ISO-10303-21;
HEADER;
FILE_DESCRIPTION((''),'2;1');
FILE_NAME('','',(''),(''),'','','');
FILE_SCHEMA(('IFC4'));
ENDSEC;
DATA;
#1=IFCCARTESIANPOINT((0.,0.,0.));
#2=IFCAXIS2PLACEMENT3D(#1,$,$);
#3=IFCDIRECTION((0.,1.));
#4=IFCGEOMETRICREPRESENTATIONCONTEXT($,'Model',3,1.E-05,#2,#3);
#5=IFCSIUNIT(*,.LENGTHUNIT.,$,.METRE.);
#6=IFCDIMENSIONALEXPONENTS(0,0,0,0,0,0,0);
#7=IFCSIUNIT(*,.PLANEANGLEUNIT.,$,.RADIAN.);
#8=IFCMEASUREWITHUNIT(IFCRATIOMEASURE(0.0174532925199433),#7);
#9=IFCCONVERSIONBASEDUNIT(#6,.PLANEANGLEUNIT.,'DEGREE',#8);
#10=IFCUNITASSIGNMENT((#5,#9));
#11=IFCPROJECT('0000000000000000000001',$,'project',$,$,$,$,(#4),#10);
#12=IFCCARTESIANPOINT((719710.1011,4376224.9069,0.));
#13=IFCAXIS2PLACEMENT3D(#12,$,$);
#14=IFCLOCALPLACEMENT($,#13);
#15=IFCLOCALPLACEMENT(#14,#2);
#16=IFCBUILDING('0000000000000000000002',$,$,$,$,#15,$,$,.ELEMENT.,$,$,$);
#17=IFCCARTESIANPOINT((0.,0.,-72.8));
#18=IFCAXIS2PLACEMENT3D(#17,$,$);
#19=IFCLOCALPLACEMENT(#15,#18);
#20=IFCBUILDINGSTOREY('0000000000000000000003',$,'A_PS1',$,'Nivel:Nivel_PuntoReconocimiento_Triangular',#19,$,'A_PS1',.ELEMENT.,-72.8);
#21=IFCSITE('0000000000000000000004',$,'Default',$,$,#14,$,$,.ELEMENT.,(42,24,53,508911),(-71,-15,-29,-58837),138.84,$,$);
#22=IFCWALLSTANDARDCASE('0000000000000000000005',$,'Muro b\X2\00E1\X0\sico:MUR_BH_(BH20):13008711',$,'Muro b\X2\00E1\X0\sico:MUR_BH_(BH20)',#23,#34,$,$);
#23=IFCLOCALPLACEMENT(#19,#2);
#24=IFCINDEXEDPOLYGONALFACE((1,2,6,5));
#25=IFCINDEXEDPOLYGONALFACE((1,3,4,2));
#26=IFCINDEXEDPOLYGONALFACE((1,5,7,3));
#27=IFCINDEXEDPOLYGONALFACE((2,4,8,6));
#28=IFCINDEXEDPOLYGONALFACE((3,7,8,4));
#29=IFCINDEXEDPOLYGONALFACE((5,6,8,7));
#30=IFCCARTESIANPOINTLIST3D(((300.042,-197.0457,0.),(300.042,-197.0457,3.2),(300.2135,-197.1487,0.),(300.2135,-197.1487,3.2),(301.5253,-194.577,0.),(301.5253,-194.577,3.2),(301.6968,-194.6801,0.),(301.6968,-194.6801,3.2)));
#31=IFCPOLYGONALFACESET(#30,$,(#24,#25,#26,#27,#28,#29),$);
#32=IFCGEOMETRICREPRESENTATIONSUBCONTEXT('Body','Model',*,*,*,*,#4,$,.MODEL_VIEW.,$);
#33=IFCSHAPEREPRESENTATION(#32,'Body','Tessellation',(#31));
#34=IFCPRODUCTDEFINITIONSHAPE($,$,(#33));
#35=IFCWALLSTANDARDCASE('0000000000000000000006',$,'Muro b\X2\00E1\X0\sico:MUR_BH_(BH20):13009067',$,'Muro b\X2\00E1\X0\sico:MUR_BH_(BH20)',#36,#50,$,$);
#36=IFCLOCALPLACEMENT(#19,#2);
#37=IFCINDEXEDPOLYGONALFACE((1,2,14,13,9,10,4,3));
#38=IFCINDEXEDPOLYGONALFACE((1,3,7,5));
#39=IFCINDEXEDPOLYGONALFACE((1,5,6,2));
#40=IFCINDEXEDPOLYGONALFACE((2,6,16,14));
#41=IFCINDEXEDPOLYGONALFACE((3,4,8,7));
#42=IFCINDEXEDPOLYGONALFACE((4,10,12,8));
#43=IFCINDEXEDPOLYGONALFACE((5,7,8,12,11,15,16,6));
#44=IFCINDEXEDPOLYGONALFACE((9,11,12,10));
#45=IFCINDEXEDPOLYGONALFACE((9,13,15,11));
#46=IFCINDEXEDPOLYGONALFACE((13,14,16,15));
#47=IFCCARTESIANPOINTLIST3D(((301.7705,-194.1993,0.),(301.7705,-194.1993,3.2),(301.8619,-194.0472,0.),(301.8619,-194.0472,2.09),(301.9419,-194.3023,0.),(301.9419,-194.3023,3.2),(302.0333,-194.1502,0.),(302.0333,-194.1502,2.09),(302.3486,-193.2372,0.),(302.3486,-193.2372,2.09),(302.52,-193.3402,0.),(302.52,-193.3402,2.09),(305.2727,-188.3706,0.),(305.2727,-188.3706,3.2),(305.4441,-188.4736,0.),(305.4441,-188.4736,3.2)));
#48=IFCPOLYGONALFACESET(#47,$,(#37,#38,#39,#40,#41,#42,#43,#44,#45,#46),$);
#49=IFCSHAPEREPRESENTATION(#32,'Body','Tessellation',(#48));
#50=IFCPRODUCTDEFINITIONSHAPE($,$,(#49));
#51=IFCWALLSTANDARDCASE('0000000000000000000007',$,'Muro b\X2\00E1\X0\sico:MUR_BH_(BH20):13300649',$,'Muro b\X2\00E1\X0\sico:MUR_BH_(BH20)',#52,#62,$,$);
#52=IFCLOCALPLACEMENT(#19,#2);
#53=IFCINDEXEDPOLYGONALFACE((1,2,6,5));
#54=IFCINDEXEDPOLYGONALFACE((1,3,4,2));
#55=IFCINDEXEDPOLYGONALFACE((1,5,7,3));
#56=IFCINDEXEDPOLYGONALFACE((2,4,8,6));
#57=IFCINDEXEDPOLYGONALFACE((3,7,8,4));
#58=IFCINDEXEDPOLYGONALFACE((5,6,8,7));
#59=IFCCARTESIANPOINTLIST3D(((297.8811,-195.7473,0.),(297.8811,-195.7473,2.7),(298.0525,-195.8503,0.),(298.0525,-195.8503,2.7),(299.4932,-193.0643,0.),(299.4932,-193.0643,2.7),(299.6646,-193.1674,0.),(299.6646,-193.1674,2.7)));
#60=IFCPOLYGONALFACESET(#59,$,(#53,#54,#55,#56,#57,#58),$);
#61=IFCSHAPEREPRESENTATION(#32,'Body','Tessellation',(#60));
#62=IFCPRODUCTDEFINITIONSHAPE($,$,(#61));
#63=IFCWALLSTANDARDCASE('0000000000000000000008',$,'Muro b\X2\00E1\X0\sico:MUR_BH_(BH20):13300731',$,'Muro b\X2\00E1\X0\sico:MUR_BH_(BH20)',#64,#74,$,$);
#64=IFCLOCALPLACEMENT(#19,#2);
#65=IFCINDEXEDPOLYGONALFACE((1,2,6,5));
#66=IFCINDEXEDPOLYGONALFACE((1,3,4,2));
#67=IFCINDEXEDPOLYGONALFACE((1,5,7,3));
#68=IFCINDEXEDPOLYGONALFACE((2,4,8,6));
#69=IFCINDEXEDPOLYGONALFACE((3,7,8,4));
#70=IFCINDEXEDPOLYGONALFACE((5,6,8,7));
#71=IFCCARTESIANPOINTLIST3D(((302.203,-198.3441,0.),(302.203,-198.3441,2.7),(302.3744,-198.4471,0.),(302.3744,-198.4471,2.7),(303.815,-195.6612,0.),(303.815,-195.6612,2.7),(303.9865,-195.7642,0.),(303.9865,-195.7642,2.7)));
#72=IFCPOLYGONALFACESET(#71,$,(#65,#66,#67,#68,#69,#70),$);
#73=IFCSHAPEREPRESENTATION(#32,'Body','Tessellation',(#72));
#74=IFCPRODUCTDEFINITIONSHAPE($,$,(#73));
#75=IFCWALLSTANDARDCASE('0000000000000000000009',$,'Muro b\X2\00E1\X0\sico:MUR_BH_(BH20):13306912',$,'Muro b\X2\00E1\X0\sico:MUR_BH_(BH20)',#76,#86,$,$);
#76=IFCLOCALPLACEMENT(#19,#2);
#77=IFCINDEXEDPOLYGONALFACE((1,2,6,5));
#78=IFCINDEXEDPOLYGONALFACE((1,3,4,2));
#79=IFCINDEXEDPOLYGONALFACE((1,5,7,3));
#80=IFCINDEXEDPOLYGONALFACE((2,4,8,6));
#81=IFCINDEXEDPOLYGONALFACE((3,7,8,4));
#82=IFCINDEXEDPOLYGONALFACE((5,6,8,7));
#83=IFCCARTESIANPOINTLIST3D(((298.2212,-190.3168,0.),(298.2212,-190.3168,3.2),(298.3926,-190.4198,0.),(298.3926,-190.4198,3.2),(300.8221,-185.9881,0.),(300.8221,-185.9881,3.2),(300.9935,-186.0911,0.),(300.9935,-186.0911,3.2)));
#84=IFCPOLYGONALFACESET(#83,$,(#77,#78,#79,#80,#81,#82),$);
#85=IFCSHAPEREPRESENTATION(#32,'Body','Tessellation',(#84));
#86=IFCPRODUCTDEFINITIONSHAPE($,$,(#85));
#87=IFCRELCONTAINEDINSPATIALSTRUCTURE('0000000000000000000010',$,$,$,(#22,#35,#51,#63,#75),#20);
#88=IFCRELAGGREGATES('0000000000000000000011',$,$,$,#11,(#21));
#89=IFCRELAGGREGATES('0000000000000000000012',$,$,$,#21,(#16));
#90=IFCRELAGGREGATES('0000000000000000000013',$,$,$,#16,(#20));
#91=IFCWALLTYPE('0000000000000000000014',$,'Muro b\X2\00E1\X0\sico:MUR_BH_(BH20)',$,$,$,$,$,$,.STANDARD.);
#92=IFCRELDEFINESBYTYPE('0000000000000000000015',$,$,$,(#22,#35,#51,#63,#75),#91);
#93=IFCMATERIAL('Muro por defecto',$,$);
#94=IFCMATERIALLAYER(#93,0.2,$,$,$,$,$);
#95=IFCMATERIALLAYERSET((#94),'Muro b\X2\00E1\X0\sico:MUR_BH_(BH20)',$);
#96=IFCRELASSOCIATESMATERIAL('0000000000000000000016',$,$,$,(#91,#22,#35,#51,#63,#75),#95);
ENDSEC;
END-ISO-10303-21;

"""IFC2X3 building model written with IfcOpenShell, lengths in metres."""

from ifc_helpers import new_model, entity, si_unit, converted_unit, direction, frame, frame_2d, origin, place, context, subcontext, project, spatial, rectangle, extrude, material, layer, layer_set, layer_usage, type_object, element, save


model = new_model("IFC2X3")

# Units and contexts
model_context = context("Model", 3, precision=1e-05, world=origin(), true_north=direction((0.0, 1.0)))
body_context = subcontext(model_context, "Body", "Model", "MODEL_VIEW")
ifc_project = project(units=[si_unit("LENGTHUNIT", "METRE"), converted_unit("PLANEANGLEUNIT", "DEGREE", entity("IfcRatioMeasure", 0.0174532925199433), si_unit("PLANEANGLEUNIT", "RADIAN"), dimensions=[0, 0, 0, 0, 0, 0, 0])], contexts=[model_context])

# Site, building, storey
site_placement = place(None, frame((719710.1011, 4376224.9069, 0.0)))
site = spatial("IfcSite", under=ifc_project, at=site_placement, Name="Default", CompositionType="ELEMENT", RefLatitude=(42, 24, 53, 508911), RefLongitude=(-71, -15, -29, -58837), RefElevation=138.84)
building_placement = place(site_placement, origin())
building = spatial("IfcBuilding", under=site, at=building_placement, CompositionType="ELEMENT")
storey_placement = place(building_placement, frame((0.0, 0.0, -72.8)))
storey = spatial("IfcBuildingStorey", under=building, at=storey_placement, Name="A_PS1", ObjectType="Nivel:Nivel_PuntoReconocimiento_Triangular", LongName="A_PS1", CompositionType="ELEMENT", Elevation=-72.8)

# Shared definitions
ifc_material_1 = material(Name="Muro por defecto")
ifc_layer = layer(ifc_material_1, 0.2)
ifc_layer_set = layer_set([ifc_layer], Name="Muro básico:MUR_BH_(BH20)")
wall_type = type_object("IfcWallType", Name="Muro básico:MUR_BH_(BH20)", PredefinedType="STANDARD", material=ifc_layer_set)

# Wall
ifc_layer_usage_1 = layer_usage(ifc_layer_set, "AXIS2", "NEGATIVE", 0.1)
wall_1_placement = place(storey_placement, frame((301.6111, -194.6285, 0.0), z_axis=(0.0, 0.0, 1.0), x_axis=(-0.515038, -0.857167, 0.0)))
element("IfcWallStandardCase", 1, at=wall_1_placement, inside=storey, type_object=wall_type, material=ifc_layer_usage_1, Name="Muro básico:MUR_BH_(BH20):13008711", ObjectType="Muro básico:MUR_BH_(BH20)", context=body_context, shape_type="SweptSolid", body=[
    extrude(rectangle(XDim=2.88, YDim=0.2, at=frame_2d((1.44, 0.0), x_axis=(-1.0, 0.0))), origin(), (0.0, 0.0, 1.0), 3.2),
])

# Wall, opening
ifc_layer_usage_2 = layer_usage(ifc_layer_set, "AXIS2", "NEGATIVE", 0.1)
wall_2_placement = place(storey_placement, frame((301.8562, -194.2508, 0.0), z_axis=(0.0, 0.0, 1.0), x_axis=(0.515038, 0.857167, 0.0)))
wall_2 = element("IfcWallStandardCase", 2, at=wall_2_placement, inside=storey, type_object=wall_type, material=ifc_layer_usage_2, Name="Muro básico:MUR_BH_(BH20):13009067", ObjectType="Muro básico:MUR_BH_(BH20)", context=body_context, shape_type="SweptSolid", body=[
    extrude(rectangle(XDim=6.8, YDim=0.2, at=frame_2d((3.4, 0.0), x_axis=(-1.0, 0.0))), origin(), (0.0, 0.0, 1.0), 3.2),
])
opening_1_placement = place(wall_2_placement, frame((11.038, 358.7878, 0.0), z_axis=(0.0, 0.0, 1.0), x_axis=(0.515038, -0.857167, 0.0)))
element("IfcOpeningElement", 3, at=opening_1_placement, cuts=wall_2, ObjectType="Opening", context=body_context, shape_type="SweptSolid", body=[
    extrude(rectangle(XDim=2.09, YDim=0.945, at=frame_2d((0.0, 0.0), x_axis=(0.0, 1.0))), frame((302.2767, -193.7452, 1.045), z_axis=(-0.857167, 0.515038, 0.0), x_axis=(0.515038, 0.857167, 0.0)), (0.0, 0.0, 1.0), 0.2),
])

# Walls
ifc_layer_usage_3 = layer_usage(ifc_layer_set, "AXIS2", "NEGATIVE", 0.1)
wall_3_placement = place(storey_placement, frame((299.5789, -193.1158, 0.0), z_axis=(0.0, 0.0, 1.0), x_axis=(-0.515038, -0.857167, 0.0)))
element("IfcWallStandardCase", 4, at=wall_3_placement, inside=storey, type_object=wall_type, material=ifc_layer_usage_3, Name="Muro básico:MUR_BH_(BH20):13300649", ObjectType="Muro básico:MUR_BH_(BH20)", context=body_context, shape_type="SweptSolid", body=[
    extrude(rectangle(XDim=3.13, YDim=0.2, at=frame_2d((1.565, 0.0), x_axis=(-1.0, 0.0))), origin(), (0.0, 0.0, 1.0), 2.7),
])
ifc_layer_usage_4 = layer_usage(ifc_layer_set, "AXIS2", "NEGATIVE", 0.1)
wall_4_placement = place(storey_placement, frame((303.9007, -195.7127, 0.0), z_axis=(0.0, 0.0, 1.0), x_axis=(-0.515038, -0.857167, 0.0)))
element("IfcWallStandardCase", 5, at=wall_4_placement, inside=storey, type_object=wall_type, material=ifc_layer_usage_4, Name="Muro básico:MUR_BH_(BH20):13300731", ObjectType="Muro básico:MUR_BH_(BH20)", context=body_context, shape_type="SweptSolid", body=[
    extrude(rectangle(XDim=3.13, YDim=0.2, at=frame_2d((1.565, 0.0), x_axis=(-1.0, 0.0))), origin(), (0.0, 0.0, 1.0), 2.7),
])
ifc_layer_usage_5 = layer_usage(ifc_layer_set, "AXIS2", "NEGATIVE", 0.1)
wall_5_placement = place(storey_placement, frame((300.9078, -186.0396, 0.0), z_axis=(0.0, 0.0, 1.0), x_axis=(-0.515038, -0.857167, 0.0)))
element("IfcWallStandardCase", 6, at=wall_5_placement, inside=storey, type_object=wall_type, material=ifc_layer_usage_5, Name="Muro básico:MUR_BH_(BH20):13306912", ObjectType="Muro básico:MUR_BH_(BH20)", context=body_context, shape_type="SweptSolid", body=[
    extrude(rectangle(XDim=5.05, YDim=0.2, at=frame_2d((2.525, 0.0), x_axis=(-1.0, 0.0))), origin(), (0.0, 0.0, 1.0), 3.2),
])

save(model, "model.ifc")
